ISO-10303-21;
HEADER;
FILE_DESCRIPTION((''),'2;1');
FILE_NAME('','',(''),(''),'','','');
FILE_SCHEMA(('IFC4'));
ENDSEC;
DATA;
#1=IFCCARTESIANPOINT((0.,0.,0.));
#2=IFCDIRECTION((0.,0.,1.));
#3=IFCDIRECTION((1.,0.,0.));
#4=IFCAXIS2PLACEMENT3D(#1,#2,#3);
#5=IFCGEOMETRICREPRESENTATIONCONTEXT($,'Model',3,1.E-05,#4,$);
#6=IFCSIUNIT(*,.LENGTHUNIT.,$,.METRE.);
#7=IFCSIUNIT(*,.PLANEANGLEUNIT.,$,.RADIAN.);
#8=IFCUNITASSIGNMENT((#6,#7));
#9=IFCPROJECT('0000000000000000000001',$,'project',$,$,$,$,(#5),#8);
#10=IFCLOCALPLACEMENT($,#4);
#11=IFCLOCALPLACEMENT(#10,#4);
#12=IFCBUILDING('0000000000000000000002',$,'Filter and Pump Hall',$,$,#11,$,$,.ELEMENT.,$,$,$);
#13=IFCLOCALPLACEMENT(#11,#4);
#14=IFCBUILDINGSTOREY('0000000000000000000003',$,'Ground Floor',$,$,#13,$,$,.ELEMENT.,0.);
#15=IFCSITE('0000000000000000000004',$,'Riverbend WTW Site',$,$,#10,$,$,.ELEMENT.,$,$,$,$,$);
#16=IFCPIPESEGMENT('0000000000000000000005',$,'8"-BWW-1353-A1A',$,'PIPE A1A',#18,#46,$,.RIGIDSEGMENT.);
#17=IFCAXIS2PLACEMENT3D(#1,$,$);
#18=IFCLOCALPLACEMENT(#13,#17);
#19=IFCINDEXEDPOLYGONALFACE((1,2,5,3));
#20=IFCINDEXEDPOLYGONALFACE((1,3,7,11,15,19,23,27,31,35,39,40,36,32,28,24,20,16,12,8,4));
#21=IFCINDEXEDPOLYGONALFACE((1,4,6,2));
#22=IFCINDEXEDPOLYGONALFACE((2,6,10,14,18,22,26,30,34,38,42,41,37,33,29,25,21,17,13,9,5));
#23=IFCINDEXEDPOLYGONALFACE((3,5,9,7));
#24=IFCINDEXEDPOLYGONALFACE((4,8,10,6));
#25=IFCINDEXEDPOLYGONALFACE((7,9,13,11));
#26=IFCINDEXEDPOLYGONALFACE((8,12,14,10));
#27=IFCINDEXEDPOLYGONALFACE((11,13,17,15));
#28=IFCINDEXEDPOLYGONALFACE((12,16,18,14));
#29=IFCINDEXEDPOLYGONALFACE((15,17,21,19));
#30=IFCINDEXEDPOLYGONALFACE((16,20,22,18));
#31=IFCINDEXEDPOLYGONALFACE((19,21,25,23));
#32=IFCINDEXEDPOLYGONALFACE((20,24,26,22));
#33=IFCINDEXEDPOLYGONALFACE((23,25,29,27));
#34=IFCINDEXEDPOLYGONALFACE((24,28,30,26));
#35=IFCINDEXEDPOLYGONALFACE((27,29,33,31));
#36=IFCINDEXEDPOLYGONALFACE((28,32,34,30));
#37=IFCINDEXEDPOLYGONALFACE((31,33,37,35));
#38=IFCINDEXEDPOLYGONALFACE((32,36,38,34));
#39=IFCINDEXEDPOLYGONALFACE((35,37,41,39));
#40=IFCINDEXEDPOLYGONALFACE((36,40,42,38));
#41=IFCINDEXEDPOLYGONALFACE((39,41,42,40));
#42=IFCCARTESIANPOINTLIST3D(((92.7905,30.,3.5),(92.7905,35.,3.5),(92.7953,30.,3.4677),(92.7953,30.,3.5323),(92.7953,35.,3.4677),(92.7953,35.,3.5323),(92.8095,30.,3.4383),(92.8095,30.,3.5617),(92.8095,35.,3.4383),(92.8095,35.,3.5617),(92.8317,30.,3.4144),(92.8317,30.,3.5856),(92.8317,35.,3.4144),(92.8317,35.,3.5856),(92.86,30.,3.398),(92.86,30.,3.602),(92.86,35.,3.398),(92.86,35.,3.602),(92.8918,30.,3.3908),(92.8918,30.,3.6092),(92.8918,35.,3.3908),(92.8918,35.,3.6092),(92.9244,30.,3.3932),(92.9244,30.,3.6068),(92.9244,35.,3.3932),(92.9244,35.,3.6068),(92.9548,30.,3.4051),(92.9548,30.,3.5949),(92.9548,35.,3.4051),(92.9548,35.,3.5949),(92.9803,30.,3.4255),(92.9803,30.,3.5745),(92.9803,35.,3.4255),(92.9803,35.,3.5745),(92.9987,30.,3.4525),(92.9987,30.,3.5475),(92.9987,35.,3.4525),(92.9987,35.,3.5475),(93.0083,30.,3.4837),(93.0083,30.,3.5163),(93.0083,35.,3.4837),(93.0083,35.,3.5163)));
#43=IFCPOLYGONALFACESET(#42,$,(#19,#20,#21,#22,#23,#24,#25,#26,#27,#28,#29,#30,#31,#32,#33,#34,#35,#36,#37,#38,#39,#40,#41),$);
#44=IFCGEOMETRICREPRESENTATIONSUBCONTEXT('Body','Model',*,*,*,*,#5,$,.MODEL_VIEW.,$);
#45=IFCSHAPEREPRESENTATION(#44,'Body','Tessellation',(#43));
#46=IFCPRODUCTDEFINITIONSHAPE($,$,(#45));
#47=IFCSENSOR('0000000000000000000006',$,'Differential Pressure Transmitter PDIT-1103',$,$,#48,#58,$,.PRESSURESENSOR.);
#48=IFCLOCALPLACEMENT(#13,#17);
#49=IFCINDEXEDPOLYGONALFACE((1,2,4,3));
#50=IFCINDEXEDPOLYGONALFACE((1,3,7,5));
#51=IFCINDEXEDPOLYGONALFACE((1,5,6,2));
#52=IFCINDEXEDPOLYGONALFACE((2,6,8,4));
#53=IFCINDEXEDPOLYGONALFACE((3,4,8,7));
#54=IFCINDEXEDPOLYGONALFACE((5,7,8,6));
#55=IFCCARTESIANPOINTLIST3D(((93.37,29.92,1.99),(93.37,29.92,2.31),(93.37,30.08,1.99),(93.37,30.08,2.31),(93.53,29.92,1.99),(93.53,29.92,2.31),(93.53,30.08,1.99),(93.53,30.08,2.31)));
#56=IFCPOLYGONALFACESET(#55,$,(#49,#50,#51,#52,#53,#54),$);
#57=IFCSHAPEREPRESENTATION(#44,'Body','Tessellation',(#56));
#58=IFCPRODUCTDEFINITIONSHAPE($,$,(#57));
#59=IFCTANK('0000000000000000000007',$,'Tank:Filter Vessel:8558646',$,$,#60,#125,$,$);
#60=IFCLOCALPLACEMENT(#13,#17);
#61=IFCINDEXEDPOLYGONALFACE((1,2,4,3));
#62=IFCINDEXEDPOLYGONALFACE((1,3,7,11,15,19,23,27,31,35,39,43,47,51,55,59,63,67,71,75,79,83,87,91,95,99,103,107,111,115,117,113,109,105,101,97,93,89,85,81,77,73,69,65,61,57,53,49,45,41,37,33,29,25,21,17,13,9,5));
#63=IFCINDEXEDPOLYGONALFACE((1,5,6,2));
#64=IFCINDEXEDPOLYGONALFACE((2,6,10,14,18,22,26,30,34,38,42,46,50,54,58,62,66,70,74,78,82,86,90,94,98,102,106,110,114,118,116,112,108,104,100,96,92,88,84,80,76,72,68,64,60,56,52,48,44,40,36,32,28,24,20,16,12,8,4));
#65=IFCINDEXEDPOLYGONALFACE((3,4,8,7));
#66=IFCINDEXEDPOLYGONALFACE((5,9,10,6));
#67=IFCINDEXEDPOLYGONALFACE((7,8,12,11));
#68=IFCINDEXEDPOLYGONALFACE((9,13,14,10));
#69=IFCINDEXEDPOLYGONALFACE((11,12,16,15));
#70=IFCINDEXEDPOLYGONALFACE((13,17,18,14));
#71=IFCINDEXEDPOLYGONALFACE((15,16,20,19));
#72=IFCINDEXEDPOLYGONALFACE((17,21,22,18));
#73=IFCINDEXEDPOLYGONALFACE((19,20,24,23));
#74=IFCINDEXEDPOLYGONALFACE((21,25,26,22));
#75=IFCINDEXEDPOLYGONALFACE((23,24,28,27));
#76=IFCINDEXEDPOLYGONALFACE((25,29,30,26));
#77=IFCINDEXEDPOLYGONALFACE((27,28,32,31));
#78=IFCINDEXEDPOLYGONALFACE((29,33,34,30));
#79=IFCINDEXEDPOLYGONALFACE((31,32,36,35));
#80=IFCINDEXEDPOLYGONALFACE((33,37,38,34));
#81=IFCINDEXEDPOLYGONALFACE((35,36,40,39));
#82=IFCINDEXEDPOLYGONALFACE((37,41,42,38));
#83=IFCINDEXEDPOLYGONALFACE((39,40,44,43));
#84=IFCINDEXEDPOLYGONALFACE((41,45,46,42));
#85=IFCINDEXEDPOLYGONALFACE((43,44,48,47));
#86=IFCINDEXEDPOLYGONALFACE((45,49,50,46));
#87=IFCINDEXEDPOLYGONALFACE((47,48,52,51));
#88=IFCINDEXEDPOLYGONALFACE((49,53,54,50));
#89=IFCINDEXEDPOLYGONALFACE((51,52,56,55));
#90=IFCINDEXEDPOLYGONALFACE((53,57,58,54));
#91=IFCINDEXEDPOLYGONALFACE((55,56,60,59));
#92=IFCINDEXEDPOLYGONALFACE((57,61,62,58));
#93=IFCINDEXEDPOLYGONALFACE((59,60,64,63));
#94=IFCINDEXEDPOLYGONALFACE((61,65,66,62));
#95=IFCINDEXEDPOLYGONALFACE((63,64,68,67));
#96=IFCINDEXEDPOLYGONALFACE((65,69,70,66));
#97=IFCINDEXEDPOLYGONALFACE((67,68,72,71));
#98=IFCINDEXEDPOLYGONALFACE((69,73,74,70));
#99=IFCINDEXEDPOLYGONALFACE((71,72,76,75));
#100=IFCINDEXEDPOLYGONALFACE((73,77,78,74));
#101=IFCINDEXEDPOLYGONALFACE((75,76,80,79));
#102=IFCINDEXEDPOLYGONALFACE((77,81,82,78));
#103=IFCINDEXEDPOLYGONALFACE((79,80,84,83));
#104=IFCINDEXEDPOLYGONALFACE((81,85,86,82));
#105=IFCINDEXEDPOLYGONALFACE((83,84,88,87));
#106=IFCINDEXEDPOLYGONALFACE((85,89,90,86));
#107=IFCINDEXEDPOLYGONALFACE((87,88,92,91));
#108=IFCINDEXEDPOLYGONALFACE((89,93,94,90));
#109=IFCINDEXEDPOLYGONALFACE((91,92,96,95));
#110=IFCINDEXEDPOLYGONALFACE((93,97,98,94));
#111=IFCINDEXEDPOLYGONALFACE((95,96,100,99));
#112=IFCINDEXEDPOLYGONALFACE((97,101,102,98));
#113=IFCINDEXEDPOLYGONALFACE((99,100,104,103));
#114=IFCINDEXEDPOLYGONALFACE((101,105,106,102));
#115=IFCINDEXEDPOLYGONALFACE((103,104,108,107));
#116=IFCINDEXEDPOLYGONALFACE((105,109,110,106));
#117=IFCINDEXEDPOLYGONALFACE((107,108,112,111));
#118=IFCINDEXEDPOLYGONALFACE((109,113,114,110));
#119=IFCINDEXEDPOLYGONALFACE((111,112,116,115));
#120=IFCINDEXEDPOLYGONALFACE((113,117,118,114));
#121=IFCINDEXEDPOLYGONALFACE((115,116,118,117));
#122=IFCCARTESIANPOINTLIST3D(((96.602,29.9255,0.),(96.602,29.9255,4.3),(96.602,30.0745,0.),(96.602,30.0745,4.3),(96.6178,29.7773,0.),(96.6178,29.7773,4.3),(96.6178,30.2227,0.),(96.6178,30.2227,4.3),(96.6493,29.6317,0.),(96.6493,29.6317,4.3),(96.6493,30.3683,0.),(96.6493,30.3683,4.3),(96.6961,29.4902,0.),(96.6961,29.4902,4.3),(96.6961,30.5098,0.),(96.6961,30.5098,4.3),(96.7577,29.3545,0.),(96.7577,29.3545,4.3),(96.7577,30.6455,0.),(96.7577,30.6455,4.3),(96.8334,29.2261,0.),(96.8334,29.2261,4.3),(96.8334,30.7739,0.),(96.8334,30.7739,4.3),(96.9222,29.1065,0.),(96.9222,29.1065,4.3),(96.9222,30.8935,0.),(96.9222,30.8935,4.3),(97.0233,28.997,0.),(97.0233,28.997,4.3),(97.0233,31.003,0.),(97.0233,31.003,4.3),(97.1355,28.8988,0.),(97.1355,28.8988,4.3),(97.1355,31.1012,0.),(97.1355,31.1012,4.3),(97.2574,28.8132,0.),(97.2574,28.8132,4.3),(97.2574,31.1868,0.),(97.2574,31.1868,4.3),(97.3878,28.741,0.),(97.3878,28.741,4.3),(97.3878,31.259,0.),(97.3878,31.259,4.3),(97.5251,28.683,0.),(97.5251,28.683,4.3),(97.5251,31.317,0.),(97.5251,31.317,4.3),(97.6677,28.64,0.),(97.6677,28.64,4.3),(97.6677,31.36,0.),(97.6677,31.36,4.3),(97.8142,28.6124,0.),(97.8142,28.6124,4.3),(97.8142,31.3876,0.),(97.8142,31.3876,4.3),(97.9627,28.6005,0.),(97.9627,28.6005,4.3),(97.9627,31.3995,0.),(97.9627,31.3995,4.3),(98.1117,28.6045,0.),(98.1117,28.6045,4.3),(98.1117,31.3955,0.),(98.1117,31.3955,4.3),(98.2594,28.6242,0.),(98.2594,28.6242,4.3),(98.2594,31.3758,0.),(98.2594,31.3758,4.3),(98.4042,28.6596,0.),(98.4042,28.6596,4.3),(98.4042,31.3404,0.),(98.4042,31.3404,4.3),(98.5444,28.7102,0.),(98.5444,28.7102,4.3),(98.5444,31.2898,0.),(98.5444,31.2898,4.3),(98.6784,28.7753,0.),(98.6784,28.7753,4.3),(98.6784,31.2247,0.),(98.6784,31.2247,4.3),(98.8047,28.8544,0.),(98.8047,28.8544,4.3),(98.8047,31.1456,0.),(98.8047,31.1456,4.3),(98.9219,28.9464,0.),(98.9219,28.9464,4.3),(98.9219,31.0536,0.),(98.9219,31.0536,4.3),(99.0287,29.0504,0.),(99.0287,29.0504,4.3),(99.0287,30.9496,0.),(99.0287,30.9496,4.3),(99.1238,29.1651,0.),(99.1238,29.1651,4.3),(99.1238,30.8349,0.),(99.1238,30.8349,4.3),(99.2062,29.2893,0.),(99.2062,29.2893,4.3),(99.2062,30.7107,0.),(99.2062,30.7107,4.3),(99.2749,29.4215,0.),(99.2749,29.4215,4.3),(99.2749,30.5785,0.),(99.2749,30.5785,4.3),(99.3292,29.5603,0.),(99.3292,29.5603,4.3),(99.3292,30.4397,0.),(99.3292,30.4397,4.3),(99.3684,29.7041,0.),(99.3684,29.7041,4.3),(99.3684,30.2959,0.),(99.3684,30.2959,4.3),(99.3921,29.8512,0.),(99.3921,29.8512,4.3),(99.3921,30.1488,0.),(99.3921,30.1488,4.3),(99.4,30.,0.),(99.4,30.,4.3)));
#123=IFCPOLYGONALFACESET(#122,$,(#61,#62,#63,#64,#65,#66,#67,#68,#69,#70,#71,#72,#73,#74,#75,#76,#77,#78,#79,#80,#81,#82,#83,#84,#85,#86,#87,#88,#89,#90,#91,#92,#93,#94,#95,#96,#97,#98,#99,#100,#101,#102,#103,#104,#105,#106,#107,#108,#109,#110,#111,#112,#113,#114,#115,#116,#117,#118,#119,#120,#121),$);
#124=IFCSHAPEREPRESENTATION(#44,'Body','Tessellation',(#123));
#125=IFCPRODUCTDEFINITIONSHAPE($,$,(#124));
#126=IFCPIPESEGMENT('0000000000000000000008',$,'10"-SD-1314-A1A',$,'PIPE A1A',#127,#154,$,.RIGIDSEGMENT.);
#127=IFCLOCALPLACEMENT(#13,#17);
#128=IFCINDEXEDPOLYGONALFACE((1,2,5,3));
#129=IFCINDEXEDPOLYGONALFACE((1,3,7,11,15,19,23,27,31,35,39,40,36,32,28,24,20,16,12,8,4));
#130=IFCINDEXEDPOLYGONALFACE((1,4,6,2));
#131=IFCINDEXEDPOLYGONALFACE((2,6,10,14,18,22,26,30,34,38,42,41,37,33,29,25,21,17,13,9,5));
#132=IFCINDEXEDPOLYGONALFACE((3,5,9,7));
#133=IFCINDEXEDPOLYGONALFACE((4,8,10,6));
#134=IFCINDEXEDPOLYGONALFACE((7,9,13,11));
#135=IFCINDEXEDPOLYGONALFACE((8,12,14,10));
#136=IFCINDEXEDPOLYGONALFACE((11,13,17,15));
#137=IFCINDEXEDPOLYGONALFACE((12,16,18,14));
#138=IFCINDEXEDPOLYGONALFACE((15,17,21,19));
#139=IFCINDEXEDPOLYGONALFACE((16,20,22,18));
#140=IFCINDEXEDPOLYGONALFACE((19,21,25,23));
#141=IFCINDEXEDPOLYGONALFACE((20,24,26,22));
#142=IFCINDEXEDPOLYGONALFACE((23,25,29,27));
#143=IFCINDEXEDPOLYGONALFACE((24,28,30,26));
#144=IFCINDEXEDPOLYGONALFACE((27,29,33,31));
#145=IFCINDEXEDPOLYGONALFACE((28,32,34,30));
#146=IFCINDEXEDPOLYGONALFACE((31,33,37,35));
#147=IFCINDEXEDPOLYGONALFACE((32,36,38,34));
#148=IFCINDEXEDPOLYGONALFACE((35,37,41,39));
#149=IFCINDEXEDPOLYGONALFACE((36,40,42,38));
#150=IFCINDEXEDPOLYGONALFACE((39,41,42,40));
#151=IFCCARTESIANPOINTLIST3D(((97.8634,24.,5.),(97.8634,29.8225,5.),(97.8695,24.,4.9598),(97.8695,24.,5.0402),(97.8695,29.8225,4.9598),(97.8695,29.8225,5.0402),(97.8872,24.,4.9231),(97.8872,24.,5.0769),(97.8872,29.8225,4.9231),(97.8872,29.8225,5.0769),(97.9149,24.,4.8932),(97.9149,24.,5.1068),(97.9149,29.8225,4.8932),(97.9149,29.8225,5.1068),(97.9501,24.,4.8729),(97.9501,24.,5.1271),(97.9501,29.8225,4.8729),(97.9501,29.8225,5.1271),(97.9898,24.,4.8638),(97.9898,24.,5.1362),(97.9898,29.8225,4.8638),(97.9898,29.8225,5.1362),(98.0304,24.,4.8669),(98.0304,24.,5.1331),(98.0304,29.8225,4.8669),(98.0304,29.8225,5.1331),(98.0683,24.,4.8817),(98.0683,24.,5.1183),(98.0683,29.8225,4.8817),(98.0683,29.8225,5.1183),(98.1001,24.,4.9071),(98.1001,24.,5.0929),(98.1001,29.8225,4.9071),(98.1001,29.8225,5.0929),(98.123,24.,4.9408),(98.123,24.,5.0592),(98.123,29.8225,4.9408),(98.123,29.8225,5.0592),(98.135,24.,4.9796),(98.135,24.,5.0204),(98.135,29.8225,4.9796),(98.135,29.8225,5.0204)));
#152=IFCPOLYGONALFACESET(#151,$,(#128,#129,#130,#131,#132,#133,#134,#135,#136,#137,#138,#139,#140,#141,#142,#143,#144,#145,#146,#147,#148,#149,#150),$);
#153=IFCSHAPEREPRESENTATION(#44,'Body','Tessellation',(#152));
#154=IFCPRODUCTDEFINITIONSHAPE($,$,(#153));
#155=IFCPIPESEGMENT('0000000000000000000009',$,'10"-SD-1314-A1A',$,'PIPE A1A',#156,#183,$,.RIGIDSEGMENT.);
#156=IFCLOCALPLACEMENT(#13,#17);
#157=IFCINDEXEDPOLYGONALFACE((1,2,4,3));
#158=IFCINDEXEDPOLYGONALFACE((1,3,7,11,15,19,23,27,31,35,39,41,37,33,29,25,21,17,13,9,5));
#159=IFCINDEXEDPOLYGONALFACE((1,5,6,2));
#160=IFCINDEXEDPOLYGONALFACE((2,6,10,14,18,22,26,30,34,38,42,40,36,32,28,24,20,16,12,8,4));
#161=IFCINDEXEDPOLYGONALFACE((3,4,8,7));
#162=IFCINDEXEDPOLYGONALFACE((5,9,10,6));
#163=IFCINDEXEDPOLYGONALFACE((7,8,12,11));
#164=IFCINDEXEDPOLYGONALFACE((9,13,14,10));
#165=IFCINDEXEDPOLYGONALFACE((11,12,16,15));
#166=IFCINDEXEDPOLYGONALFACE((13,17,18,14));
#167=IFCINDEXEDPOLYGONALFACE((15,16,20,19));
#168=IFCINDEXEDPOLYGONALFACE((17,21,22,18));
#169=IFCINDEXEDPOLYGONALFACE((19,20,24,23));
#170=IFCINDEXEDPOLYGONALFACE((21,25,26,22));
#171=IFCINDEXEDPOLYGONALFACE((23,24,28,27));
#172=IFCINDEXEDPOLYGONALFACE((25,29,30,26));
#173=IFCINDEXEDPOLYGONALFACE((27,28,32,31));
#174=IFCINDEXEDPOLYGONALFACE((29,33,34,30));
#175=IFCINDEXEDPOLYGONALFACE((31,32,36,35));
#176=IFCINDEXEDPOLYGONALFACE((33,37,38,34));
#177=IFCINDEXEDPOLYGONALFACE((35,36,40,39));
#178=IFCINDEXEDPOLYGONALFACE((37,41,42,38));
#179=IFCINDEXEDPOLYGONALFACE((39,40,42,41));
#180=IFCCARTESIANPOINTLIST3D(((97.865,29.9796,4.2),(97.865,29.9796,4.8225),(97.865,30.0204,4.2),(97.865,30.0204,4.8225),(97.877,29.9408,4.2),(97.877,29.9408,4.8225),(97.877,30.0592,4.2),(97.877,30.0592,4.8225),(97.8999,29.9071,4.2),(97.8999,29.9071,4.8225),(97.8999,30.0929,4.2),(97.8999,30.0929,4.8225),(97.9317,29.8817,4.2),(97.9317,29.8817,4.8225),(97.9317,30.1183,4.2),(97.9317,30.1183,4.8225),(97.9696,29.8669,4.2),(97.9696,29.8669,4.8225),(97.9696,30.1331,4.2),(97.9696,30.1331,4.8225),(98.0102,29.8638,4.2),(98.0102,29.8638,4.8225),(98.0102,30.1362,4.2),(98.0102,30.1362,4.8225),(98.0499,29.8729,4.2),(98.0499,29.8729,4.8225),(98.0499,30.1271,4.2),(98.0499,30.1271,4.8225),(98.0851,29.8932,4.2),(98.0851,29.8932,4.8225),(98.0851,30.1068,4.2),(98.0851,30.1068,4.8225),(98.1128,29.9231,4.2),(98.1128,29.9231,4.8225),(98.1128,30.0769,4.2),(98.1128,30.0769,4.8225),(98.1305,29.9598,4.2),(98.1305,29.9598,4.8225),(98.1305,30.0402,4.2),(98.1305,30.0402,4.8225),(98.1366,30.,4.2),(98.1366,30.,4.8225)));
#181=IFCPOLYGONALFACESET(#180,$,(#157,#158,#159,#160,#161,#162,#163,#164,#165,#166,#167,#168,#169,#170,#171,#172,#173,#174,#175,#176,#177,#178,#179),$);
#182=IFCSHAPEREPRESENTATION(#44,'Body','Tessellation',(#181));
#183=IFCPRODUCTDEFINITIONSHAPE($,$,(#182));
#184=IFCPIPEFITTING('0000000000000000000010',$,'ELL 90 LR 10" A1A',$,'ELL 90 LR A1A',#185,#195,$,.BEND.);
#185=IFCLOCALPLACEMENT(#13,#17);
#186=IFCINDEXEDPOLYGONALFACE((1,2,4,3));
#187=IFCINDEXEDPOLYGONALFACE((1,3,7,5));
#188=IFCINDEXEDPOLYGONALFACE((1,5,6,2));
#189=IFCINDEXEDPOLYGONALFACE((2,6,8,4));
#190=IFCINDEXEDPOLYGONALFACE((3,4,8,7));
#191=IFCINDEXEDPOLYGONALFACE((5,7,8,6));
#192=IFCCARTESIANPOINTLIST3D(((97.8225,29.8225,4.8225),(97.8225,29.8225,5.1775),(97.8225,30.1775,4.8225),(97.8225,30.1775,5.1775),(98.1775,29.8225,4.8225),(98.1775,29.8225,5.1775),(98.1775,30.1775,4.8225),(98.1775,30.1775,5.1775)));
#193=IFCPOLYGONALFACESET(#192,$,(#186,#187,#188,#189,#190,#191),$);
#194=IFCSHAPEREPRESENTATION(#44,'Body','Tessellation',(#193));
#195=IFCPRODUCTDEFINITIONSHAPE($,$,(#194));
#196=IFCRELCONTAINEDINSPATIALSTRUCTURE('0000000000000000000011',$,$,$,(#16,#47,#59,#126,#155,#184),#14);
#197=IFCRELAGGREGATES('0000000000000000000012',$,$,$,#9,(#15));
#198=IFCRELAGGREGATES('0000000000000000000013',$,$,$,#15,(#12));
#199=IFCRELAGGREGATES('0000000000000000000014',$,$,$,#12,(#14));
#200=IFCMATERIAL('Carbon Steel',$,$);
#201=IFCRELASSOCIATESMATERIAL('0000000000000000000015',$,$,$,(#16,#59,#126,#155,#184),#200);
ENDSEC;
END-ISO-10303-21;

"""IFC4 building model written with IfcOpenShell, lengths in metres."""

from ifc_helpers import new_model, si_unit, frame, origin_with_axes, origin_2d, place, context, subcontext, project, spatial, rectangle, circle, extrude, material, element, save


model = new_model("IFC4")

# Units and contexts
model_context = context("Model", 3, precision=1e-05, world=origin_with_axes())
body_context = subcontext(model_context, "Body", "Model", "MODEL_VIEW")
ifc_project = project(units=[si_unit("LENGTHUNIT", "METRE"), si_unit("PLANEANGLEUNIT", "RADIAN")], contexts=[model_context])

# Site, building, storey
site_placement = place(None, origin_with_axes())
site = spatial("IfcSite", under=ifc_project, at=site_placement, Name="Riverbend WTW Site", CompositionType="ELEMENT")
building_placement = place(site_placement, origin_with_axes())
building = spatial("IfcBuilding", under=site, at=building_placement, Name="Filter and Pump Hall", CompositionType="ELEMENT")
storey_placement = place(building_placement, origin_with_axes())
storey = spatial("IfcBuildingStorey", under=building, at=storey_placement, Name="Ground Floor", CompositionType="ELEMENT", Elevation=0.0)

# Pipe segment
ifc_material_1 = material(Name="Carbon Steel")
pipe_segment_1_placement = place(None, frame((92.9, 30.0, 3.5), z_axis=(0.0, 0.0, 1.0), x_axis=(1.0, 0.0, 0.0)))
element("IfcPipeSegment", 1, at=pipe_segment_1_placement, inside=storey, material=ifc_material_1, Name="8\"-BWW-1353-A1A", ObjectType="PIPE A1A", PredefinedType="RIGIDSEGMENT", context=body_context, shape_type="SweptSolid", body=[
    extrude(circle(Radius=0.1095, at=origin_2d()), frame((0.0, 0.0, 0.0), z_axis=(0.0, 1.0, 0.0), x_axis=(-1.0, 0.0, 0.0)), (0.0, 0.0, 1.0), 5.0),
])

# Sensor
sensor_1_placement = place(None, frame((93.45, 30.0, 2.15), z_axis=(0.0, 0.0, 1.0), x_axis=(1.0, 0.0, 0.0)))
element("IfcSensor", 2, at=sensor_1_placement, inside=storey, Name="Differential Pressure Transmitter PDIT-1103", PredefinedType="PRESSURESENSOR", context=body_context, shape_type="SweptSolid", body=[
    extrude(rectangle(XDim=0.16, YDim=0.16, at=origin_2d()), frame((0.0, 0.0, -0.16), z_axis=(0.0, 0.0, 1.0), x_axis=(1.0, 0.0, 0.0)), (0.0, 0.0, 1.0), 0.32),
])

# Tank
tank_placement = place(None, frame((98.0, 30.0, 0.0), z_axis=(0.0, 0.0, 1.0), x_axis=(1.0, 0.0, 0.0)))
element("IfcTank", 3, at=tank_placement, inside=storey, material=ifc_material_1, Name="Tank:Filter Vessel:8558646", context=body_context, shape_type="SweptSolid", body=[
    extrude(circle(Radius=1.4, at=origin_2d()), origin_with_axes(), (0.0, 0.0, 1.0), 4.3),
])

# Pipe segments
pipe_segment_2_placement = place(None, frame((98.0, 24.0, 5.0), z_axis=(0.0, 0.0, 1.0), x_axis=(1.0, 0.0, 0.0)))
element("IfcPipeSegment", 4, at=pipe_segment_2_placement, inside=storey, material=ifc_material_1, Name="10\"-SD-1314-A1A", ObjectType="PIPE A1A", PredefinedType="RIGIDSEGMENT", context=body_context, shape_type="SweptSolid", body=[
    extrude(circle(Radius=0.1366, at=origin_2d()), frame((0.0, 0.0, 0.0), z_axis=(0.0, 1.0, 0.0), x_axis=(-1.0, 0.0, 0.0)), (0.0, 0.0, 1.0), 5.8225),
])
pipe_segment_3_placement = place(None, frame((98.0, 30.0, 4.8225), z_axis=(0.0, 0.0, 1.0), x_axis=(1.0, 0.0, 0.0)))
element("IfcPipeSegment", 5, at=pipe_segment_3_placement, inside=storey, material=ifc_material_1, Name="10\"-SD-1314-A1A", ObjectType="PIPE A1A", PredefinedType="RIGIDSEGMENT", context=body_context, shape_type="SweptSolid", body=[
    extrude(circle(Radius=0.1366, at=origin_2d()), frame((0.0, 0.0, 0.0), z_axis=(0.0, 0.0, -1.0), x_axis=(1.0, 0.0, 0.0)), (0.0, 0.0, 1.0), 0.6225),
])

# Pipe fitting
pipe_fitting_placement = place(None, frame((98.0, 30.0, 5.0), z_axis=(0.0, 0.0, 1.0), x_axis=(1.0, 0.0, 0.0)))
element("IfcPipeFitting", 6, at=pipe_fitting_placement, inside=storey, material=ifc_material_1, Name="ELL 90 LR 10\" A1A", ObjectType="ELL 90 LR A1A", PredefinedType="BEND", context=body_context, shape_type="SweptSolid", body=[
    extrude(rectangle(XDim=0.355, YDim=0.355, at=origin_2d()), frame((0.0, 0.0, -0.1775), z_axis=(0.0, 0.0, 1.0), x_axis=(1.0, 0.0, 0.0)), (0.0, 0.0, 1.0), 0.355),
])

save(model, "model.ifc")
